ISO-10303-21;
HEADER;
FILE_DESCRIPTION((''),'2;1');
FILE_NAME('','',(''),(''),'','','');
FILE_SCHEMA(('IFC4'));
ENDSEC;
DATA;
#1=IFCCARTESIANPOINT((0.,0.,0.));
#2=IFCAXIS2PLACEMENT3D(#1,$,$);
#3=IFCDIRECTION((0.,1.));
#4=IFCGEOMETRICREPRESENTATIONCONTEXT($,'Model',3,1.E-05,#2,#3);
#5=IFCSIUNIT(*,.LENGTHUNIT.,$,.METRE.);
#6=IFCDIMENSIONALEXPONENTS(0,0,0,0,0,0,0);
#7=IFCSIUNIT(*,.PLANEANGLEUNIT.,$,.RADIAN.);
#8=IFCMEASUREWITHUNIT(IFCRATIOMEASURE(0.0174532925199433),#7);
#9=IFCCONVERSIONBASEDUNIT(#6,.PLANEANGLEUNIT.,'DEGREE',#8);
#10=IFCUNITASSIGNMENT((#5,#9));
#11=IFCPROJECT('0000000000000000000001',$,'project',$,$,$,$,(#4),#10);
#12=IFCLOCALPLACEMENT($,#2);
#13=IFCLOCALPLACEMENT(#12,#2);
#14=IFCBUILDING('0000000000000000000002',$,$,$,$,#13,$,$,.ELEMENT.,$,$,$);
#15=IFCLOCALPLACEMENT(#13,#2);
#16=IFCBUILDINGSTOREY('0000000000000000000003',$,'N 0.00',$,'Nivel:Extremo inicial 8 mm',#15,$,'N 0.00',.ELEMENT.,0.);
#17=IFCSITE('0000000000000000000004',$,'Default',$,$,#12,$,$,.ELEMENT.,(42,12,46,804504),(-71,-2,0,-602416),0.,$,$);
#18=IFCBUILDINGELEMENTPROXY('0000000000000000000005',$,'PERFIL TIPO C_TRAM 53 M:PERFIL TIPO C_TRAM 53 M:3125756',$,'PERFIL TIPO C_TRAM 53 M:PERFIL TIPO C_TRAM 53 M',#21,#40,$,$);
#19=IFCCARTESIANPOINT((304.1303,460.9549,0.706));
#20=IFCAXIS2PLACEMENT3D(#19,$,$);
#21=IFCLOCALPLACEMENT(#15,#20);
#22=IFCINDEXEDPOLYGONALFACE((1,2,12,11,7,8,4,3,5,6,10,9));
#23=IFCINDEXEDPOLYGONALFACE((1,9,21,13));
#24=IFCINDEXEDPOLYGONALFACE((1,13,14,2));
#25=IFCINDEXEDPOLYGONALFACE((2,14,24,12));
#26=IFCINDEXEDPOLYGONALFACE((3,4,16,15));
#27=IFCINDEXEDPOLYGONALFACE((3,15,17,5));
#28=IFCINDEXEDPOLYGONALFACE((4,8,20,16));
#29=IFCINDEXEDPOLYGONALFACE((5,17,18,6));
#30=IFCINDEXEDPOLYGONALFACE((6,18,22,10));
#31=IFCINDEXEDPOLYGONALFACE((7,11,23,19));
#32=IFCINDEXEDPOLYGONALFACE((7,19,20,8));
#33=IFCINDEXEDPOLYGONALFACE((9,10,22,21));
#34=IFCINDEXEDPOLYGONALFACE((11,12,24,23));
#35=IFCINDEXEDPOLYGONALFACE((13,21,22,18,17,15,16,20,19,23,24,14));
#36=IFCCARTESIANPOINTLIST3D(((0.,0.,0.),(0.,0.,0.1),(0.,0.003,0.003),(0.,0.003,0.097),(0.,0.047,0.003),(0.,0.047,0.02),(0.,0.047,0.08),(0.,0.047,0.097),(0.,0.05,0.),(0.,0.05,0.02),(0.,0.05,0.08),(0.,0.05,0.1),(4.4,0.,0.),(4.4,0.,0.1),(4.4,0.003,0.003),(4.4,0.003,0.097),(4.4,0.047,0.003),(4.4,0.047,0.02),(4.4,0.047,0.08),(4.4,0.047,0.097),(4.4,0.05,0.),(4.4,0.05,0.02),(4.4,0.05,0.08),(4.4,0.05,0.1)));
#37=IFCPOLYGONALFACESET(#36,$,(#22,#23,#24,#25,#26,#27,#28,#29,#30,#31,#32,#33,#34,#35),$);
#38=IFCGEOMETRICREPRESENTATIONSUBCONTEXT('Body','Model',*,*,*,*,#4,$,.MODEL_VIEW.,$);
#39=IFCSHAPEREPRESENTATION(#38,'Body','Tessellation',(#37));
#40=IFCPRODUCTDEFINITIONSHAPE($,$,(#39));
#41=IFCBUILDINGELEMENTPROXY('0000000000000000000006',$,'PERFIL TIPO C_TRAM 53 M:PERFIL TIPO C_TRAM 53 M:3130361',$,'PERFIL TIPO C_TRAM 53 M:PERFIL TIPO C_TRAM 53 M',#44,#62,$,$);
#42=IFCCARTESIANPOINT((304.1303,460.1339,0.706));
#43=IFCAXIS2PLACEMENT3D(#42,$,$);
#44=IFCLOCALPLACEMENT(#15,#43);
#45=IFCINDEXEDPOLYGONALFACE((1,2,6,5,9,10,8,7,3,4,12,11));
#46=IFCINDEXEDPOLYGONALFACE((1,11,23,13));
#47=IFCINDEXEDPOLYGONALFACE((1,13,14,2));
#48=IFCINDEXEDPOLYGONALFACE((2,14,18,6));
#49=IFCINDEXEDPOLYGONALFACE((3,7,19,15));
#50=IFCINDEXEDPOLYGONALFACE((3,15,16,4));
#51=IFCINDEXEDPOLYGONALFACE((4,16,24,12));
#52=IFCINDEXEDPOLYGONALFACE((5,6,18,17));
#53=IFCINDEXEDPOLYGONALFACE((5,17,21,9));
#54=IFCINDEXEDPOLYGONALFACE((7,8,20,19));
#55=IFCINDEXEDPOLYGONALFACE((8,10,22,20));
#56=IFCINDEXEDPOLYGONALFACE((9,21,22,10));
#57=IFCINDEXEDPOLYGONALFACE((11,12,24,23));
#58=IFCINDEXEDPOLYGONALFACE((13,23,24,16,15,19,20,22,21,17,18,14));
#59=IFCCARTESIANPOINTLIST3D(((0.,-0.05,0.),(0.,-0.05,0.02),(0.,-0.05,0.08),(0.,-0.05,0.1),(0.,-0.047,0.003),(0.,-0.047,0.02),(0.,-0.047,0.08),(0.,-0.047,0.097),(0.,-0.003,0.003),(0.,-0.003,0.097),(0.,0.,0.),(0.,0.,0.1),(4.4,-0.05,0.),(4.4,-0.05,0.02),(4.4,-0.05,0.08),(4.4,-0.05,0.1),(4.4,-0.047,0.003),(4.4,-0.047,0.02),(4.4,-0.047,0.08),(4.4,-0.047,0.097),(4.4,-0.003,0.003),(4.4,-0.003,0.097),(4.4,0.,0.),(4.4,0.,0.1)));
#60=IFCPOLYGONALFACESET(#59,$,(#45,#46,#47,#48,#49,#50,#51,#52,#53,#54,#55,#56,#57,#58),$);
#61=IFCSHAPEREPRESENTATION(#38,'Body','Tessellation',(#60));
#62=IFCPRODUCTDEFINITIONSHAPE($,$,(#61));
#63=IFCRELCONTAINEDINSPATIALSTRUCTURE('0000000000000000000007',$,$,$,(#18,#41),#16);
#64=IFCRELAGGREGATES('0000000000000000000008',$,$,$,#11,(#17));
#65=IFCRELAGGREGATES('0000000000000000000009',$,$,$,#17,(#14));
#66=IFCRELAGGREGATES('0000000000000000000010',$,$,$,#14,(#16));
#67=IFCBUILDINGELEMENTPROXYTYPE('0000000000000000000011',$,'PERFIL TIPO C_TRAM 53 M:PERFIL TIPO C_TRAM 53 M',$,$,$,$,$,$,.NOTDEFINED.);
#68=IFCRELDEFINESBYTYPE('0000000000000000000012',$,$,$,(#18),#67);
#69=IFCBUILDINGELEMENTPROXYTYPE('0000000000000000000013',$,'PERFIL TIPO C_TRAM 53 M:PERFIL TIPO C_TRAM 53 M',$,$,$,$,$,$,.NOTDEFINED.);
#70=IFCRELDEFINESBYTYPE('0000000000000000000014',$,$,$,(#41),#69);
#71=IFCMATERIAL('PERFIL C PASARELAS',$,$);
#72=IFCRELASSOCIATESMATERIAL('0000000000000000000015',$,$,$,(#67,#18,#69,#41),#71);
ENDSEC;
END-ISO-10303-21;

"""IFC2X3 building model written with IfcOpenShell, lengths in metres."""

from ifc_helpers import new_model, entity, si_unit, converted_unit, direction, frame, origin, place, context, subcontext, project, spatial, polyline, outline, extrude, source, transform, mapped, material, type_object, type_shapes, element, save


model = new_model("IFC2X3")

# Units and contexts
model_context = context("Model", 3, precision=1e-05, world=origin(), true_north=direction((0.0, 1.0)))
body_context = subcontext(model_context, "Body", "Model", "MODEL_VIEW")
ifc_project = project(units=[si_unit("LENGTHUNIT", "METRE"), converted_unit("PLANEANGLEUNIT", "DEGREE", entity("IfcRatioMeasure", 0.0174532925199433), si_unit("PLANEANGLEUNIT", "RADIAN"), dimensions=[0, 0, 0, 0, 0, 0, 0])], contexts=[model_context])

# Site, building, storey
site_placement = place(None, origin())
site = spatial("IfcSite", under=ifc_project, at=site_placement, Name="Default", CompositionType="ELEMENT", RefLatitude=(42, 12, 46, 804504), RefLongitude=(-71, -2, 0, -602416), RefElevation=0.0)
building_placement = place(site_placement, origin())
building = spatial("IfcBuilding", under=site, at=building_placement, CompositionType="ELEMENT")
storey_placement = place(building_placement, origin())
storey = spatial("IfcBuildingStorey", under=building, at=storey_placement, Name="N 0.00", ObjectType="Nivel:Extremo inicial 8 mm", LongName="N 0.00", CompositionType="ELEMENT", Elevation=0.0)

# Building element proxies
ifc_material_1 = material(Name="PERFIL C PASARELAS")
building_element_proxy_type_1 = type_object("IfcBuildingElementProxyType", Name="PERFIL TIPO C_TRAM 53 M:PERFIL TIPO C_TRAM 53 M", PredefinedType="NOTDEFINED", material=ifc_material_1)
shared_shape_1 = source(origin(), body_context, "Body", "SweptSolid", [
    extrude(outline(polyline([(-0.0172, 0.03), (-0.0142, 0.03), (-0.0142, 0.047), (0.0298, 0.047), (0.0298, -0.047), (-0.0142, -0.047), (-0.0142, -0.03), (-0.0172, -0.03), (-0.0172, -0.05), (0.0328, -0.05), (0.0328, 0.05), (-0.0172, 0.05), (-0.0172, 0.03)])), frame((0.0, 0.0328, 0.05), z_axis=(1.0, 0.0, 0.0), x_axis=(0.0, -1.0, 0.0)), (0.0, 0.0, 1.0), 4.4),
])
type_shapes(building_element_proxy_type_1, [shared_shape_1])
proxy_1_placement = place(storey_placement, frame((304.1303, 460.9549, 0.706)))
element("IfcBuildingElementProxy", 1, at=proxy_1_placement, inside=storey, type_object=building_element_proxy_type_1, material=ifc_material_1, Name="PERFIL TIPO C_TRAM 53 M:PERFIL TIPO C_TRAM 53 M:3125756", ObjectType="PERFIL TIPO C_TRAM 53 M:PERFIL TIPO C_TRAM 53 M", context=body_context, shape_type="MappedRepresentation", body=[
    mapped(shared_shape_1, transform((0.0, 0.0, 0.0), scale=1.0)),
])
building_element_proxy_type_2 = type_object("IfcBuildingElementProxyType", Name="PERFIL TIPO C_TRAM 53 M:PERFIL TIPO C_TRAM 53 M", PredefinedType="NOTDEFINED", material=ifc_material_1)
shared_shape_2 = source(origin(), body_context, "Body", "SweptSolid", [
    extrude(outline(polyline([(0.03, -0.0172), (0.05, -0.0172), (0.05, 0.0328), (-0.05, 0.0328), (-0.05, -0.0172), (-0.03, -0.0172), (-0.03, -0.0142), (-0.047, -0.0142), (-0.047, 0.0298), (0.047, 0.0298), (0.047, -0.0142), (0.03, -0.0142), (0.03, -0.0172)])), frame((0.0, -0.0328, 0.05), z_axis=(1.0, 0.0, 0.0), x_axis=(0.0, 0.0, -1.0)), (0.0, 0.0, 1.0), 4.4),
])
type_shapes(building_element_proxy_type_2, [shared_shape_2])
proxy_2_placement = place(storey_placement, frame((304.1303, 460.1339, 0.706)))
element("IfcBuildingElementProxy", 2, at=proxy_2_placement, inside=storey, type_object=building_element_proxy_type_2, material=ifc_material_1, Name="PERFIL TIPO C_TRAM 53 M:PERFIL TIPO C_TRAM 53 M:3130361", ObjectType="PERFIL TIPO C_TRAM 53 M:PERFIL TIPO C_TRAM 53 M", context=body_context, shape_type="MappedRepresentation", body=[
    mapped(shared_shape_2, transform((0.0, 0.0, 0.0), scale=1.0)),
])

save(model, "model.ifc")
